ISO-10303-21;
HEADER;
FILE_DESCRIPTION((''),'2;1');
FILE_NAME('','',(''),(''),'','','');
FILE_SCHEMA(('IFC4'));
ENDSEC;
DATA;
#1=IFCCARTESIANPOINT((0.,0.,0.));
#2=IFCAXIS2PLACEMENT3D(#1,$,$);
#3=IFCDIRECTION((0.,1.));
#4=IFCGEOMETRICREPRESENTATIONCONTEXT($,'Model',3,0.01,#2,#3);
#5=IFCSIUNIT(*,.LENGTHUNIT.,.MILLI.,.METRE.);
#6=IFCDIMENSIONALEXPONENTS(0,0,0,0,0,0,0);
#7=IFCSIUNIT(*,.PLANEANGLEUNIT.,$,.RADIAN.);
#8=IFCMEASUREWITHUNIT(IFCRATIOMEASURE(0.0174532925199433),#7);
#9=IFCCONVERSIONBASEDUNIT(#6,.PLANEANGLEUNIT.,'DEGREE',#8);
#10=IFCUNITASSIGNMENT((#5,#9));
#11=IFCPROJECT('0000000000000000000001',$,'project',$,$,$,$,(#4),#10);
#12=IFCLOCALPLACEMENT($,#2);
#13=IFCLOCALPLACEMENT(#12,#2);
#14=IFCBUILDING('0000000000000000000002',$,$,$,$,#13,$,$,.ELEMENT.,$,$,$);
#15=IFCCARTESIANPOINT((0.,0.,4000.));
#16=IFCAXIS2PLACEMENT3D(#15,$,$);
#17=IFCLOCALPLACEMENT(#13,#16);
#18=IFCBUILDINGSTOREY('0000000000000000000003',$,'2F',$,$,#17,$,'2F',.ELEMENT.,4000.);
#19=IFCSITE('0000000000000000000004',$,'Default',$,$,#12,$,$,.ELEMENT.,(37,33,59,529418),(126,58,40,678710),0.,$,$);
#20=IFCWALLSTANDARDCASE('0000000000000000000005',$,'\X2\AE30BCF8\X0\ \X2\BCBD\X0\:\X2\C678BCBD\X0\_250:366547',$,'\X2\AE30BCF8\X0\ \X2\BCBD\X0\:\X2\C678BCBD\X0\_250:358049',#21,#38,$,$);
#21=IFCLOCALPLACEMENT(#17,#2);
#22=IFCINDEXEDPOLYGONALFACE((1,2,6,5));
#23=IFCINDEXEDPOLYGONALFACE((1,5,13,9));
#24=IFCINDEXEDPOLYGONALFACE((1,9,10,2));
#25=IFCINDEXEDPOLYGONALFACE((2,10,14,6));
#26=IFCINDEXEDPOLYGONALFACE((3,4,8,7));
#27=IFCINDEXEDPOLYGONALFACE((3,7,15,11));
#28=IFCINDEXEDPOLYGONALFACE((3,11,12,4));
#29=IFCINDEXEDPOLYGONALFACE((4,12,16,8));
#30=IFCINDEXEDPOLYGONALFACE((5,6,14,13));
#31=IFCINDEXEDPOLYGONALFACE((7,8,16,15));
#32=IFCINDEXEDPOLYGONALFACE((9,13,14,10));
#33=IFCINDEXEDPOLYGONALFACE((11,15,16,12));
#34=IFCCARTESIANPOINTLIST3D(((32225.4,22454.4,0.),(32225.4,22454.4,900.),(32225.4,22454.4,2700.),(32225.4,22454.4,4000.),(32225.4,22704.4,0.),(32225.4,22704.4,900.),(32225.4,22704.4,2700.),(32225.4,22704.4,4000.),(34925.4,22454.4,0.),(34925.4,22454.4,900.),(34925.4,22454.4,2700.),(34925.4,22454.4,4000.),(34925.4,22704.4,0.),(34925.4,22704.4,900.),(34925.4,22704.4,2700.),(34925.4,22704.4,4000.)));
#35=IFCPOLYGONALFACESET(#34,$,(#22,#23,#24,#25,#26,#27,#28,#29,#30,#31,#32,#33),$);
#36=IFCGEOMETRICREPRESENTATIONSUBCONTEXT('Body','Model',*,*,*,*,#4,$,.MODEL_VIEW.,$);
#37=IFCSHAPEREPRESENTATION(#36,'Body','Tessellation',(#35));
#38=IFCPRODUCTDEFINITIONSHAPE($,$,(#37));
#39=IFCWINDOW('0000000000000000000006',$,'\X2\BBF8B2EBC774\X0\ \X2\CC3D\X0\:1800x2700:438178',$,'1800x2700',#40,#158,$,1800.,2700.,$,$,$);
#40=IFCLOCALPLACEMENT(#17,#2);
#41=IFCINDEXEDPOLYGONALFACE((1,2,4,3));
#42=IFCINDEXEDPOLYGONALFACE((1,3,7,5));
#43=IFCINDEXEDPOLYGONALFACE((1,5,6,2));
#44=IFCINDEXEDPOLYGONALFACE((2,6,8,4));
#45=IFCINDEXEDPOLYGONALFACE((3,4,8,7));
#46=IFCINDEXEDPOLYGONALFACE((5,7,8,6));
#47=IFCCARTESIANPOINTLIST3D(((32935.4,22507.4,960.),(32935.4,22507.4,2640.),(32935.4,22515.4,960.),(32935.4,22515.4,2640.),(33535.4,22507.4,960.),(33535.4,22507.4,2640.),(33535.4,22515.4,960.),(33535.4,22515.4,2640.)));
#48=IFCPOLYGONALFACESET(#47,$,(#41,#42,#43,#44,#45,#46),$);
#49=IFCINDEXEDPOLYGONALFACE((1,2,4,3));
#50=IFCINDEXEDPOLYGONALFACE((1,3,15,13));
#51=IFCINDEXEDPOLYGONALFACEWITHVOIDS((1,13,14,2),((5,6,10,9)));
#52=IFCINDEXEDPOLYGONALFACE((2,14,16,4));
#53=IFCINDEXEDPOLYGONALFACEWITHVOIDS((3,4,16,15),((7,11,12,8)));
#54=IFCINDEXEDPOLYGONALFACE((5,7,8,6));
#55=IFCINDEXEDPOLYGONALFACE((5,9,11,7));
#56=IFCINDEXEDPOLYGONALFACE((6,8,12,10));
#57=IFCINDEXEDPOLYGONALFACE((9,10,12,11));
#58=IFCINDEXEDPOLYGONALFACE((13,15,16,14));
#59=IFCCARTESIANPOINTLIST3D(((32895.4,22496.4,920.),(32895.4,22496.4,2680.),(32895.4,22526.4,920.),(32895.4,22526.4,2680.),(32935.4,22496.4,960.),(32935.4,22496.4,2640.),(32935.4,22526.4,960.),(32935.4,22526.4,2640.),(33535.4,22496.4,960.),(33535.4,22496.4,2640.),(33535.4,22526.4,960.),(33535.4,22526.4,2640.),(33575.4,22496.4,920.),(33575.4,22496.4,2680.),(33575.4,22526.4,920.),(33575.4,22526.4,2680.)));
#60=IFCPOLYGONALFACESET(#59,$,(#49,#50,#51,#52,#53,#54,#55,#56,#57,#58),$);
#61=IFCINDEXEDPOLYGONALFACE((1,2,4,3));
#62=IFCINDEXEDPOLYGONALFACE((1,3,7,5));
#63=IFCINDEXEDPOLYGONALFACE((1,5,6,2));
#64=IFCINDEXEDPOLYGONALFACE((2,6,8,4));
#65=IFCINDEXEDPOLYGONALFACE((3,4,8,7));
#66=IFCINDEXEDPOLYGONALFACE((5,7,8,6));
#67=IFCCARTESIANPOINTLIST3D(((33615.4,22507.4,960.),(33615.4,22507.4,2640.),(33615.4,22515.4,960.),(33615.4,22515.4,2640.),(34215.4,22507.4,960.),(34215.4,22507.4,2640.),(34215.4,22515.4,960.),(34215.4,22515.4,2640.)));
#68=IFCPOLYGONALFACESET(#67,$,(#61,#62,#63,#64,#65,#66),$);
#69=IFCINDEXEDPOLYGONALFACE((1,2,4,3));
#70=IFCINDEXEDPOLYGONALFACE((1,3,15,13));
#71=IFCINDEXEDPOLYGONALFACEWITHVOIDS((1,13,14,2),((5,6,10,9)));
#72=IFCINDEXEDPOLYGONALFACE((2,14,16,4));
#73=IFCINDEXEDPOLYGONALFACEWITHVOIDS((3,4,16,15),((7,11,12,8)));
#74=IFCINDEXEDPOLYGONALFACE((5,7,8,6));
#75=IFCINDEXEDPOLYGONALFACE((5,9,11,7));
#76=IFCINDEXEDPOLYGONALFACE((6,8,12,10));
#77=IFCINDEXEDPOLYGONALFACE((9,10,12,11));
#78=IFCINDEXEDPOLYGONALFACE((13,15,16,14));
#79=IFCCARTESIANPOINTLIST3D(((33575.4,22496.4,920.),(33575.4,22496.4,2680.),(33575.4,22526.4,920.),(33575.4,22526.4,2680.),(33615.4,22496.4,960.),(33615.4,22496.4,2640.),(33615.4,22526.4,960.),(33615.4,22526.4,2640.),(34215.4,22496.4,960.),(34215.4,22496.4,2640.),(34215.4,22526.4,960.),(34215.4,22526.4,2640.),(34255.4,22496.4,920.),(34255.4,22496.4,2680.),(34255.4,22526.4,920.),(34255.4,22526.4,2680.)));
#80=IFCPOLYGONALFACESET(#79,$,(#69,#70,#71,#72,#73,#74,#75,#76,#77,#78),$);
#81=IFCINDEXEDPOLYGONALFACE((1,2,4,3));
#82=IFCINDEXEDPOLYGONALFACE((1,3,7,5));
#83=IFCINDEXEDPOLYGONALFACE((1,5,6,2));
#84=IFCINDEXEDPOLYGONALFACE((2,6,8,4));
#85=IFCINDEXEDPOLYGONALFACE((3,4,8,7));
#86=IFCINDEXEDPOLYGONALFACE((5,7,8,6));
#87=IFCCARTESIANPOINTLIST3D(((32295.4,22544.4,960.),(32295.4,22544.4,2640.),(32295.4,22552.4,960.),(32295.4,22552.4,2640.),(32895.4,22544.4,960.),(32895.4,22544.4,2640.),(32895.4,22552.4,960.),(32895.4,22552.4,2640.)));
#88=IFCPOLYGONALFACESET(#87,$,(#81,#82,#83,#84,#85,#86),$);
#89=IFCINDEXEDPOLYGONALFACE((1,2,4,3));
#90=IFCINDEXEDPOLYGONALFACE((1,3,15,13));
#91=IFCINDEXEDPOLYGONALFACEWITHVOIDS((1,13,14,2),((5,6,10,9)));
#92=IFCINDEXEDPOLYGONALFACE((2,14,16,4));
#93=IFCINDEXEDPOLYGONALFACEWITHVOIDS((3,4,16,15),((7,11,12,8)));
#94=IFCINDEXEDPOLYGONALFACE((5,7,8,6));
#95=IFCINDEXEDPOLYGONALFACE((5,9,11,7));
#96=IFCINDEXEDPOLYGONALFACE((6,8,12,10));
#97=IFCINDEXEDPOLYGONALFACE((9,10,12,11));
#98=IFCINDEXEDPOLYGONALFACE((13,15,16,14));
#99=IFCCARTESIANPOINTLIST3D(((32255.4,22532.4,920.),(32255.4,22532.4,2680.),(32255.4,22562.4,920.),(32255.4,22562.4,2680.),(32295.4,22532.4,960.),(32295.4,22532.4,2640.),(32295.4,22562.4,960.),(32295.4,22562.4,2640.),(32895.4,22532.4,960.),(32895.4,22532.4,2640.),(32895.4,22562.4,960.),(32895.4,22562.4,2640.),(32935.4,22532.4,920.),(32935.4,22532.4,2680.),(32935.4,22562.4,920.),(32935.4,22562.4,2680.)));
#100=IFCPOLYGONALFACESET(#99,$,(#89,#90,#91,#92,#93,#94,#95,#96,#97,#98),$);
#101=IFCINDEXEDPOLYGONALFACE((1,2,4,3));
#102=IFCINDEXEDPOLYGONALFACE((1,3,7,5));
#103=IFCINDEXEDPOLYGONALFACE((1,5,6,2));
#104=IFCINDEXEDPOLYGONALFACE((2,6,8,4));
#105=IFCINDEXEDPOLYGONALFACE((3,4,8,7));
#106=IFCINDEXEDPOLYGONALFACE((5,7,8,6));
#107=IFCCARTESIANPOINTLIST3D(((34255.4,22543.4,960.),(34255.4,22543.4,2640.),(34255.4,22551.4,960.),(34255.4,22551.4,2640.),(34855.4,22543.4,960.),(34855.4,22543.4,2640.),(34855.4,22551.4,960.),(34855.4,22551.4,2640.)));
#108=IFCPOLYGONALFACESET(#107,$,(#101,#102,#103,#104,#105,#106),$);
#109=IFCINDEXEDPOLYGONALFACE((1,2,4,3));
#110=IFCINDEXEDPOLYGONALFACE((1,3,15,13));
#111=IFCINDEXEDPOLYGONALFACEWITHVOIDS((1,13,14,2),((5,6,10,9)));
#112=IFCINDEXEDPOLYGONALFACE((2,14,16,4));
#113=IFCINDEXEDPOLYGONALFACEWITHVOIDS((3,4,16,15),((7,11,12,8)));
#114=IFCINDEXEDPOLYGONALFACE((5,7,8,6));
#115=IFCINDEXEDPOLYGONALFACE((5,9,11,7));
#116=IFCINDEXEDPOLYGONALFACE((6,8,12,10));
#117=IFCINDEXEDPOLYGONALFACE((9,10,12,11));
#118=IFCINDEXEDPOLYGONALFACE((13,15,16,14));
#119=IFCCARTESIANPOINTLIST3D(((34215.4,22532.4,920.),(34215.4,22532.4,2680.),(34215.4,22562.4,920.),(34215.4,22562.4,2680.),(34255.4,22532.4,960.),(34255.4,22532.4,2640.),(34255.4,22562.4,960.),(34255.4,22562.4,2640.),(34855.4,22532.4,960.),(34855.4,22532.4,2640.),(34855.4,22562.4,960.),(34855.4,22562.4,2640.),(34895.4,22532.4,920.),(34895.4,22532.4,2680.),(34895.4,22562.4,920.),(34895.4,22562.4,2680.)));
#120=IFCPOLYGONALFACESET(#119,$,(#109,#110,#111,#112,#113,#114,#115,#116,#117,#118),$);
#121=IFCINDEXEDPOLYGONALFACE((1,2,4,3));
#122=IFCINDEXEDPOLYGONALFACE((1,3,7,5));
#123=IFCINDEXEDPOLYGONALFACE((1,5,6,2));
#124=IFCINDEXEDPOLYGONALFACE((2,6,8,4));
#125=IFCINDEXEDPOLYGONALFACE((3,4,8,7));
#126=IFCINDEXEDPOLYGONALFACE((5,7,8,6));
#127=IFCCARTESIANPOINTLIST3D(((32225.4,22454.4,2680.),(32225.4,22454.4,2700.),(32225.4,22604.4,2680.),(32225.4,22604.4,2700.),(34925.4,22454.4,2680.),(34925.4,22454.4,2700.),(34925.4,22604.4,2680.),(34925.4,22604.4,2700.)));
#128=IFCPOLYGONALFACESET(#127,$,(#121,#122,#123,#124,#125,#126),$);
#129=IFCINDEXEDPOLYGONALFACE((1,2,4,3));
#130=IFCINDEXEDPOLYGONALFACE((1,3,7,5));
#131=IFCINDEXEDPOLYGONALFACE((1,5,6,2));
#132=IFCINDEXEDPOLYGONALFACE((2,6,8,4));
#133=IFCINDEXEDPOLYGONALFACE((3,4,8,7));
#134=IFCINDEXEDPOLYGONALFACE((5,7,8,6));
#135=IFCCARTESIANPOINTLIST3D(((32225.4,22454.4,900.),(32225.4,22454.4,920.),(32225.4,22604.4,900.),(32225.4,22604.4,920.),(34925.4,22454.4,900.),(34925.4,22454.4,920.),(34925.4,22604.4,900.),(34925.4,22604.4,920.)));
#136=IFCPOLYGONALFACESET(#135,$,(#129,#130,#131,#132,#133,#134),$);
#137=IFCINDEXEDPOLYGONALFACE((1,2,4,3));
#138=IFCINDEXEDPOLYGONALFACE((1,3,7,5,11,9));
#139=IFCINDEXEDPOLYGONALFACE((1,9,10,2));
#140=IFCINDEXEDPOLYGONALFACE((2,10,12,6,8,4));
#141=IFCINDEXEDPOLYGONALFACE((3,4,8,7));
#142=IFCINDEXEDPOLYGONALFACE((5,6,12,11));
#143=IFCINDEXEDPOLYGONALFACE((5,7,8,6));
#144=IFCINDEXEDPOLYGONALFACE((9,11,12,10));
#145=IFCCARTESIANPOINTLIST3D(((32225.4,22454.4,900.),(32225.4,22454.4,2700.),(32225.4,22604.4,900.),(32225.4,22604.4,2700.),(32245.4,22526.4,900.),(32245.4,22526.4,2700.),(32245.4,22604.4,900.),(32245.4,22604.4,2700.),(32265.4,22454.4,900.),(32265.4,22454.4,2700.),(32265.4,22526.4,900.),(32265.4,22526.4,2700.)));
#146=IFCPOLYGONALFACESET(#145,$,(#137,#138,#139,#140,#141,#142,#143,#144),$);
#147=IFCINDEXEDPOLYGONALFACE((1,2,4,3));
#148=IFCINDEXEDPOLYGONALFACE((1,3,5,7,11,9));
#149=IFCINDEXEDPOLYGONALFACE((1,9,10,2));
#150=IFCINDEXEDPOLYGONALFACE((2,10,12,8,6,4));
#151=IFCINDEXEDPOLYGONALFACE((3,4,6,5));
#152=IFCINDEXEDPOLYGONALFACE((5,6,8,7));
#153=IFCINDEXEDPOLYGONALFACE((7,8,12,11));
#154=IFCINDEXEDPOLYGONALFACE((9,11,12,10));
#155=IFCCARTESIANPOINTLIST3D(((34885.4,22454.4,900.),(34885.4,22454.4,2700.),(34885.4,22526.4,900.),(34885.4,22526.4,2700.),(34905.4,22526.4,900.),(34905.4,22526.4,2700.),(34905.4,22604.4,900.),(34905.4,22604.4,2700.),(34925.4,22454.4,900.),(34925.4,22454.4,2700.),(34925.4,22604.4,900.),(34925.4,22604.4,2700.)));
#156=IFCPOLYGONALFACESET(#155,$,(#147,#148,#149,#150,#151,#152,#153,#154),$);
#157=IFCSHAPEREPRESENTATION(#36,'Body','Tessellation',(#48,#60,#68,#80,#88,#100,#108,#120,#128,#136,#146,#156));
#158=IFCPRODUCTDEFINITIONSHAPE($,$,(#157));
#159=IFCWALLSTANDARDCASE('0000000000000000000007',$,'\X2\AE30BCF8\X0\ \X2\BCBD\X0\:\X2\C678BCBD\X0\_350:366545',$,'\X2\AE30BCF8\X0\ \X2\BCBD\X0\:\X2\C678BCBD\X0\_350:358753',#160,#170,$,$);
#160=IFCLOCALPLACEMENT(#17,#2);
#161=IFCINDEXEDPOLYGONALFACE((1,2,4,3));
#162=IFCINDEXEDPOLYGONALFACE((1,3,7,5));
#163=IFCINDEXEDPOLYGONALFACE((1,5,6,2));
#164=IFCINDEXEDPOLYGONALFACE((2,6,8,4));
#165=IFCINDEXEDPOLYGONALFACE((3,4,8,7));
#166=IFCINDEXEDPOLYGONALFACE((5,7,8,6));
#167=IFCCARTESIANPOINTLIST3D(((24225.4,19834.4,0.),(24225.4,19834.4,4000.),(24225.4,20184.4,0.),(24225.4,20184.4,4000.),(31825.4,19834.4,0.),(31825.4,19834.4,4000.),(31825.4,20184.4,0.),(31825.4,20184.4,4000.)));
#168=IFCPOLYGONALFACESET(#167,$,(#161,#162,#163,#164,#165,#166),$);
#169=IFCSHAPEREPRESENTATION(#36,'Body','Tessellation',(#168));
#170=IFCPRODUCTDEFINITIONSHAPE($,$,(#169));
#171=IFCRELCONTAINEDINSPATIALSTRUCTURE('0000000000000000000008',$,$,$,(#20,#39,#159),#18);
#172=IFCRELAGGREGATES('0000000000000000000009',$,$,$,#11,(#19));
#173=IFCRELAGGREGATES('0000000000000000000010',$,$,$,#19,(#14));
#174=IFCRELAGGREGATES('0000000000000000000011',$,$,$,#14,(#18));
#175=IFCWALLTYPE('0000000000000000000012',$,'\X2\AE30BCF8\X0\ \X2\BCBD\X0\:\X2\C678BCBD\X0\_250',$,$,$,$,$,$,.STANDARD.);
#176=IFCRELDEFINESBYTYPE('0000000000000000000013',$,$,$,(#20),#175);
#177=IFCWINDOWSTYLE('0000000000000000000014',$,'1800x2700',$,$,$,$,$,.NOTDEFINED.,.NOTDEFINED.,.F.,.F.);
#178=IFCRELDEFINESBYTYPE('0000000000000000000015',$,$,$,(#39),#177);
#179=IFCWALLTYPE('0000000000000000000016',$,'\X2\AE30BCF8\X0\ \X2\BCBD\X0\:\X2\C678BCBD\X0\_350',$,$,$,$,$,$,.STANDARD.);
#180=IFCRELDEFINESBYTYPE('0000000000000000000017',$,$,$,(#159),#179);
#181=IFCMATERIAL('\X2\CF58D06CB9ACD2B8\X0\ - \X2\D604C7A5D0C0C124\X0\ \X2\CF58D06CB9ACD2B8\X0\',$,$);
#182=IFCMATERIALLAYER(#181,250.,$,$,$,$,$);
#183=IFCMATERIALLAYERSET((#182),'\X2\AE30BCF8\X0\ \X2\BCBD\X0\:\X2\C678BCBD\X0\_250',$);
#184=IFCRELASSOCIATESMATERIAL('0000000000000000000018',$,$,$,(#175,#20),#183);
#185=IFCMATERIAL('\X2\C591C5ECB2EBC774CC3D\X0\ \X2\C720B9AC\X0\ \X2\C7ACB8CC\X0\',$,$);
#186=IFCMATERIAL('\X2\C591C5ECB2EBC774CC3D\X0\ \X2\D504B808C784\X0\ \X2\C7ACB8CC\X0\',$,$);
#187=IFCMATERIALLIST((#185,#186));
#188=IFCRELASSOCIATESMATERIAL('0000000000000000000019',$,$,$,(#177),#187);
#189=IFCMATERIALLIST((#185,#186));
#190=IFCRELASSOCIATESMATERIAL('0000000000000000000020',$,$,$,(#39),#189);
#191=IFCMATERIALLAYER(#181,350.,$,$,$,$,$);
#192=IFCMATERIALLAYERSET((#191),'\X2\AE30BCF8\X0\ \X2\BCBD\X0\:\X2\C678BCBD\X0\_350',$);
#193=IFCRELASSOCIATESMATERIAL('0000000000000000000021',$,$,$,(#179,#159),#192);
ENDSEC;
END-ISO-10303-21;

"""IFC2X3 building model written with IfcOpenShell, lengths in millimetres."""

from ifc_helpers import new_model, entity, si_unit, converted_unit, direction, frame, frame_2d, origin, origin_2d_with_axis, place, context, subcontext, project, spatial, polyline, rectangle, outline, extrude, source, transform, mapped, material, material_list, layer, layer_set, layer_usage, type_object, type_shapes, element, fill, save


model = new_model("IFC2X3")

# Units and contexts
model_context = context("Model", 3, precision=0.01, world=origin(), true_north=direction((0.0, 1.0)))
body_context = subcontext(model_context, "Body", "Model", "MODEL_VIEW")
ifc_project = project(units=[si_unit("LENGTHUNIT", "METRE", prefix="MILLI"), converted_unit("PLANEANGLEUNIT", "DEGREE", entity("IfcRatioMeasure", 0.0174532925199433), si_unit("PLANEANGLEUNIT", "RADIAN"), dimensions=[0, 0, 0, 0, 0, 0, 0])], contexts=[model_context])

# Site, building, storey
site_placement = place(None, origin())
site = spatial("IfcSite", under=ifc_project, at=site_placement, Name="Default", CompositionType="ELEMENT", RefLatitude=(37, 33, 59, 529418), RefLongitude=(126, 58, 40, 678710), RefElevation=0.0)
building_placement = place(site_placement, origin())
building = spatial("IfcBuilding", under=site, at=building_placement, CompositionType="ELEMENT")
storey_placement = place(building_placement, frame((0.0, 0.0, 4000.0)))
storey = spatial("IfcBuildingStorey", under=building, at=storey_placement, Name="2F", LongName="2F", CompositionType="ELEMENT", Elevation=4000.0)

# Shared definitions
ifc_material_1 = material(Name="콘크리트 - 현장타설 콘크리트")

# Wall, opening, window
ifc_material_2 = material(Name="양여닫이창 유리 재료")
ifc_material_3 = material(Name="양여닫이창 프레임 재료")
ifc_layer_1 = layer(ifc_material_1, 250.0)
ifc_layer_set_1 = layer_set([ifc_layer_1], Name="기본 벽:외벽_250")
ifc_layer_usage_1 = layer_usage(ifc_layer_set_1, "AXIS2", "NEGATIVE", 125.0)
wall_type_1 = type_object("IfcWallType", Name="기본 벽:외벽_250", PredefinedType="STANDARD", material=ifc_layer_set_1)
wall_1_placement = place(storey_placement, frame((34925.4, 22579.4, 0.0), z_axis=(0.0, 0.0, 1.0), x_axis=(-1.0, 0.0, 0.0)))
wall_1 = element("IfcWallStandardCase", 1, at=wall_1_placement, inside=storey, type_object=wall_type_1, material=ifc_layer_usage_1, Name="기본 벽:외벽_250:366547", ObjectType="기본 벽:외벽_250:358049", context=body_context, shape_type="SweptSolid", body=[
    extrude(rectangle(XDim=2700.0, YDim=250.0, at=frame_2d((1350.0, 0.0), x_axis=(-1.0, 0.0))), origin(), (0.0, 0.0, 1.0), 4000.0),
])
opening_1_placement = place(wall_1_placement, frame((0.0, -125.0, 900.0)))
opening_1 = element("IfcOpeningElement", 2, at=opening_1_placement, cuts=wall_1, ObjectType="Opening", context=body_context, shape_type="SweptSolid", body=[
    extrude(rectangle(XDim=1800.0, YDim=2700.0, at=frame_2d((900.0, 1350.0), x_axis=(1.0, 0.0))), frame((0.0, 0.0, 0.0), z_axis=(0.0, 1.0, 0.0), x_axis=(0.0, 0.0, 1.0)), (0.0, 0.0, 1.0), 250.0),
])
ifc_material_list_1 = material_list([ifc_material_2, ifc_material_3])
ifc_material_list_2 = material_list([ifc_material_2, ifc_material_3])
window_style_1 = type_object("IfcWindowStyle", Name="1800x2700", ConstructionType="NOTDEFINED", OperationType="NOTDEFINED", ParameterTakesPrecedence=False, Sizeable=False, material=ifc_material_list_2)
shared_shape_1 = source(origin(), body_context, "Body", "SweptSolid", [
    extrude(rectangle(XDim=8.0, YDim=600.0, at=frame_2d((0.0, 0.0), x_axis=(1.0, 0.0))), frame((1690.0, 193.0, 60.0), z_axis=(0.0, 0.0, 1.0), x_axis=(0.0, 1.0, 0.0)), (0.0, 0.0, 1.0), 1680.0),
    extrude(outline(polyline([(-880.0, -340.0), (880.0, -340.0), (880.0, 340.0), (-880.0, 340.0), (-880.0, -340.0)]), holes=[polyline([(840.0, -300.0), (-840.0, -300.0), (-840.0, 300.0), (840.0, 300.0), (840.0, -300.0)])]), frame((1690.0, 178.0, 900.0), z_axis=(0.0, 1.0, 0.0), x_axis=(0.0, 0.0, -1.0)), (0.0, 0.0, 1.0), 30.0),
    extrude(rectangle(XDim=8.0, YDim=600.0, at=origin_2d_with_axis()), frame((1010.0, 193.0, 60.0), z_axis=(0.0, 0.0, 1.0), x_axis=(0.0, 1.0, 0.0)), (0.0, 0.0, 1.0), 1680.0),
    extrude(outline(polyline([(-880.0, -340.0), (880.0, -340.0), (880.0, 340.0), (-880.0, 340.0), (-880.0, -340.0)]), holes=[polyline([(840.0, -300.0), (-840.0, -300.0), (-840.0, 300.0), (840.0, 300.0), (840.0, -300.0)])]), frame((1010.0, 178.0, 900.0), z_axis=(0.0, 1.0, 0.0), x_axis=(0.0, 0.0, -1.0)), (0.0, 0.0, 1.0), 30.0),
    extrude(rectangle(XDim=8.0, YDim=600.0, at=frame_2d((0.0, 0.0), x_axis=(1.0, 0.0))), frame((2330.0, 156.0, 60.0), z_axis=(0.0, 0.0, 1.0), x_axis=(0.0, 1.0, 0.0)), (0.0, 0.0, 1.0), 1680.0),
    extrude(outline(polyline([(-880.0, -340.0), (880.0, -340.0), (880.0, 340.0), (-880.0, 340.0), (-880.0, -340.0)]), holes=[polyline([(840.0, -300.0), (-840.0, -300.0), (-840.0, 300.0), (840.0, 300.0), (840.0, -300.0)])]), frame((2330.0, 142.0, 900.0), z_axis=(0.0, 1.0, 0.0), x_axis=(0.0, 0.0, -1.0)), (0.0, 0.0, 1.0), 30.0),
    extrude(rectangle(XDim=8.0, YDim=600.0, at=frame_2d((0.0, 0.0), x_axis=(1.0, 0.0))), frame((370.0, 157.0, 60.0), z_axis=(0.0, 0.0, 1.0), x_axis=(0.0, 1.0, 0.0)), (0.0, 0.0, 1.0), 1680.0),
    extrude(outline(polyline([(-880.0, -340.0), (880.0, -340.0), (880.0, 340.0), (-880.0, 340.0), (-880.0, -340.0)]), holes=[polyline([(840.0, -300.0), (-840.0, -300.0), (-840.0, 300.0), (840.0, 300.0), (840.0, -300.0)])]), frame((370.0, 142.0, 900.0), z_axis=(0.0, 1.0, 0.0), x_axis=(0.0, 0.0, -1.0)), (0.0, 0.0, 1.0), 30.0),
    extrude(rectangle(XDim=2700.0, YDim=150.0, at=origin_2d_with_axis()), frame((1350.0, 175.0, 1780.0), z_axis=(0.0, 0.0, 1.0), x_axis=(-1.0, 0.0, 0.0)), (0.0, 0.0, 1.0), 20.0),
    extrude(rectangle(XDim=2700.0, YDim=150.0, at=origin_2d_with_axis()), frame((1350.0, 175.0, 0.0), z_axis=(0.0, 0.0, 1.0), x_axis=(-1.0, 0.0, 0.0)), (0.0, 0.0, 1.0), 20.0),
    extrude(outline(polyline([(-74.0, -20.0), (-2.0, -20.0), (-2.0, 0.0), (76.0, 0.0), (76.0, 20.0), (-74.0, 20.0), (-74.0, -20.0)])), frame((2680.0, 176.0, 0.0), z_axis=(0.0, 0.0, 1.0), x_axis=(0.0, -1.0, 0.0)), (0.0, 0.0, 1.0), 1800.0),
    extrude(outline(polyline([(-20.0, -74.0), (20.0, -74.0), (20.0, 76.0), (0.0, 76.0), (0.0, -2.0), (-20.0, -2.0), (-20.0, -74.0)])), frame((20.0, 176.0, 0.0), z_axis=(0.0, 0.0, 1.0), x_axis=(-1.0, 0.0, 0.0)), (0.0, 0.0, 1.0), 1800.0),
])
type_shapes(window_style_1, [shared_shape_1])
window_1_placement = place(opening_1_placement, origin())
window_1 = element("IfcWindow", 3, at=window_1_placement, inside=storey, type_object=window_style_1, material=ifc_material_list_1, Name="미닫이 창:1800x2700:438178", ObjectType="1800x2700", OverallHeight=1800.0, OverallWidth=2700.0, context=body_context, shape_type="MappedRepresentation", body=[
    mapped(shared_shape_1, transform((0.0, 0.0, 0.0), scale=1.0)),
])
fill(opening_1, window_1)

# Wall
ifc_layer_2 = layer(ifc_material_1, 350.0)
ifc_layer_set_2 = layer_set([ifc_layer_2], Name="기본 벽:외벽_350")
ifc_layer_usage_2 = layer_usage(ifc_layer_set_2, "AXIS2", "NEGATIVE", 175.0)
wall_type_2 = type_object("IfcWallType", Name="기본 벽:외벽_350", PredefinedType="STANDARD", material=ifc_layer_set_2)
wall_2_placement = place(storey_placement, frame((31825.4, 20009.4, 0.0), z_axis=(0.0, 0.0, 1.0), x_axis=(-1.0, 0.0, 0.0)))
element("IfcWallStandardCase", 4, at=wall_2_placement, inside=storey, type_object=wall_type_2, material=ifc_layer_usage_2, Name="기본 벽:외벽_350:366545", ObjectType="기본 벽:외벽_350:358753", context=body_context, shape_type="SweptSolid", body=[
    extrude(rectangle(XDim=7600.0, YDim=350.0, at=frame_2d((3800.0, 0.0), x_axis=(-1.0, 0.0))), origin(), (0.0, 0.0, 1.0), 4000.0),
])

save(model, "model.ifc")
